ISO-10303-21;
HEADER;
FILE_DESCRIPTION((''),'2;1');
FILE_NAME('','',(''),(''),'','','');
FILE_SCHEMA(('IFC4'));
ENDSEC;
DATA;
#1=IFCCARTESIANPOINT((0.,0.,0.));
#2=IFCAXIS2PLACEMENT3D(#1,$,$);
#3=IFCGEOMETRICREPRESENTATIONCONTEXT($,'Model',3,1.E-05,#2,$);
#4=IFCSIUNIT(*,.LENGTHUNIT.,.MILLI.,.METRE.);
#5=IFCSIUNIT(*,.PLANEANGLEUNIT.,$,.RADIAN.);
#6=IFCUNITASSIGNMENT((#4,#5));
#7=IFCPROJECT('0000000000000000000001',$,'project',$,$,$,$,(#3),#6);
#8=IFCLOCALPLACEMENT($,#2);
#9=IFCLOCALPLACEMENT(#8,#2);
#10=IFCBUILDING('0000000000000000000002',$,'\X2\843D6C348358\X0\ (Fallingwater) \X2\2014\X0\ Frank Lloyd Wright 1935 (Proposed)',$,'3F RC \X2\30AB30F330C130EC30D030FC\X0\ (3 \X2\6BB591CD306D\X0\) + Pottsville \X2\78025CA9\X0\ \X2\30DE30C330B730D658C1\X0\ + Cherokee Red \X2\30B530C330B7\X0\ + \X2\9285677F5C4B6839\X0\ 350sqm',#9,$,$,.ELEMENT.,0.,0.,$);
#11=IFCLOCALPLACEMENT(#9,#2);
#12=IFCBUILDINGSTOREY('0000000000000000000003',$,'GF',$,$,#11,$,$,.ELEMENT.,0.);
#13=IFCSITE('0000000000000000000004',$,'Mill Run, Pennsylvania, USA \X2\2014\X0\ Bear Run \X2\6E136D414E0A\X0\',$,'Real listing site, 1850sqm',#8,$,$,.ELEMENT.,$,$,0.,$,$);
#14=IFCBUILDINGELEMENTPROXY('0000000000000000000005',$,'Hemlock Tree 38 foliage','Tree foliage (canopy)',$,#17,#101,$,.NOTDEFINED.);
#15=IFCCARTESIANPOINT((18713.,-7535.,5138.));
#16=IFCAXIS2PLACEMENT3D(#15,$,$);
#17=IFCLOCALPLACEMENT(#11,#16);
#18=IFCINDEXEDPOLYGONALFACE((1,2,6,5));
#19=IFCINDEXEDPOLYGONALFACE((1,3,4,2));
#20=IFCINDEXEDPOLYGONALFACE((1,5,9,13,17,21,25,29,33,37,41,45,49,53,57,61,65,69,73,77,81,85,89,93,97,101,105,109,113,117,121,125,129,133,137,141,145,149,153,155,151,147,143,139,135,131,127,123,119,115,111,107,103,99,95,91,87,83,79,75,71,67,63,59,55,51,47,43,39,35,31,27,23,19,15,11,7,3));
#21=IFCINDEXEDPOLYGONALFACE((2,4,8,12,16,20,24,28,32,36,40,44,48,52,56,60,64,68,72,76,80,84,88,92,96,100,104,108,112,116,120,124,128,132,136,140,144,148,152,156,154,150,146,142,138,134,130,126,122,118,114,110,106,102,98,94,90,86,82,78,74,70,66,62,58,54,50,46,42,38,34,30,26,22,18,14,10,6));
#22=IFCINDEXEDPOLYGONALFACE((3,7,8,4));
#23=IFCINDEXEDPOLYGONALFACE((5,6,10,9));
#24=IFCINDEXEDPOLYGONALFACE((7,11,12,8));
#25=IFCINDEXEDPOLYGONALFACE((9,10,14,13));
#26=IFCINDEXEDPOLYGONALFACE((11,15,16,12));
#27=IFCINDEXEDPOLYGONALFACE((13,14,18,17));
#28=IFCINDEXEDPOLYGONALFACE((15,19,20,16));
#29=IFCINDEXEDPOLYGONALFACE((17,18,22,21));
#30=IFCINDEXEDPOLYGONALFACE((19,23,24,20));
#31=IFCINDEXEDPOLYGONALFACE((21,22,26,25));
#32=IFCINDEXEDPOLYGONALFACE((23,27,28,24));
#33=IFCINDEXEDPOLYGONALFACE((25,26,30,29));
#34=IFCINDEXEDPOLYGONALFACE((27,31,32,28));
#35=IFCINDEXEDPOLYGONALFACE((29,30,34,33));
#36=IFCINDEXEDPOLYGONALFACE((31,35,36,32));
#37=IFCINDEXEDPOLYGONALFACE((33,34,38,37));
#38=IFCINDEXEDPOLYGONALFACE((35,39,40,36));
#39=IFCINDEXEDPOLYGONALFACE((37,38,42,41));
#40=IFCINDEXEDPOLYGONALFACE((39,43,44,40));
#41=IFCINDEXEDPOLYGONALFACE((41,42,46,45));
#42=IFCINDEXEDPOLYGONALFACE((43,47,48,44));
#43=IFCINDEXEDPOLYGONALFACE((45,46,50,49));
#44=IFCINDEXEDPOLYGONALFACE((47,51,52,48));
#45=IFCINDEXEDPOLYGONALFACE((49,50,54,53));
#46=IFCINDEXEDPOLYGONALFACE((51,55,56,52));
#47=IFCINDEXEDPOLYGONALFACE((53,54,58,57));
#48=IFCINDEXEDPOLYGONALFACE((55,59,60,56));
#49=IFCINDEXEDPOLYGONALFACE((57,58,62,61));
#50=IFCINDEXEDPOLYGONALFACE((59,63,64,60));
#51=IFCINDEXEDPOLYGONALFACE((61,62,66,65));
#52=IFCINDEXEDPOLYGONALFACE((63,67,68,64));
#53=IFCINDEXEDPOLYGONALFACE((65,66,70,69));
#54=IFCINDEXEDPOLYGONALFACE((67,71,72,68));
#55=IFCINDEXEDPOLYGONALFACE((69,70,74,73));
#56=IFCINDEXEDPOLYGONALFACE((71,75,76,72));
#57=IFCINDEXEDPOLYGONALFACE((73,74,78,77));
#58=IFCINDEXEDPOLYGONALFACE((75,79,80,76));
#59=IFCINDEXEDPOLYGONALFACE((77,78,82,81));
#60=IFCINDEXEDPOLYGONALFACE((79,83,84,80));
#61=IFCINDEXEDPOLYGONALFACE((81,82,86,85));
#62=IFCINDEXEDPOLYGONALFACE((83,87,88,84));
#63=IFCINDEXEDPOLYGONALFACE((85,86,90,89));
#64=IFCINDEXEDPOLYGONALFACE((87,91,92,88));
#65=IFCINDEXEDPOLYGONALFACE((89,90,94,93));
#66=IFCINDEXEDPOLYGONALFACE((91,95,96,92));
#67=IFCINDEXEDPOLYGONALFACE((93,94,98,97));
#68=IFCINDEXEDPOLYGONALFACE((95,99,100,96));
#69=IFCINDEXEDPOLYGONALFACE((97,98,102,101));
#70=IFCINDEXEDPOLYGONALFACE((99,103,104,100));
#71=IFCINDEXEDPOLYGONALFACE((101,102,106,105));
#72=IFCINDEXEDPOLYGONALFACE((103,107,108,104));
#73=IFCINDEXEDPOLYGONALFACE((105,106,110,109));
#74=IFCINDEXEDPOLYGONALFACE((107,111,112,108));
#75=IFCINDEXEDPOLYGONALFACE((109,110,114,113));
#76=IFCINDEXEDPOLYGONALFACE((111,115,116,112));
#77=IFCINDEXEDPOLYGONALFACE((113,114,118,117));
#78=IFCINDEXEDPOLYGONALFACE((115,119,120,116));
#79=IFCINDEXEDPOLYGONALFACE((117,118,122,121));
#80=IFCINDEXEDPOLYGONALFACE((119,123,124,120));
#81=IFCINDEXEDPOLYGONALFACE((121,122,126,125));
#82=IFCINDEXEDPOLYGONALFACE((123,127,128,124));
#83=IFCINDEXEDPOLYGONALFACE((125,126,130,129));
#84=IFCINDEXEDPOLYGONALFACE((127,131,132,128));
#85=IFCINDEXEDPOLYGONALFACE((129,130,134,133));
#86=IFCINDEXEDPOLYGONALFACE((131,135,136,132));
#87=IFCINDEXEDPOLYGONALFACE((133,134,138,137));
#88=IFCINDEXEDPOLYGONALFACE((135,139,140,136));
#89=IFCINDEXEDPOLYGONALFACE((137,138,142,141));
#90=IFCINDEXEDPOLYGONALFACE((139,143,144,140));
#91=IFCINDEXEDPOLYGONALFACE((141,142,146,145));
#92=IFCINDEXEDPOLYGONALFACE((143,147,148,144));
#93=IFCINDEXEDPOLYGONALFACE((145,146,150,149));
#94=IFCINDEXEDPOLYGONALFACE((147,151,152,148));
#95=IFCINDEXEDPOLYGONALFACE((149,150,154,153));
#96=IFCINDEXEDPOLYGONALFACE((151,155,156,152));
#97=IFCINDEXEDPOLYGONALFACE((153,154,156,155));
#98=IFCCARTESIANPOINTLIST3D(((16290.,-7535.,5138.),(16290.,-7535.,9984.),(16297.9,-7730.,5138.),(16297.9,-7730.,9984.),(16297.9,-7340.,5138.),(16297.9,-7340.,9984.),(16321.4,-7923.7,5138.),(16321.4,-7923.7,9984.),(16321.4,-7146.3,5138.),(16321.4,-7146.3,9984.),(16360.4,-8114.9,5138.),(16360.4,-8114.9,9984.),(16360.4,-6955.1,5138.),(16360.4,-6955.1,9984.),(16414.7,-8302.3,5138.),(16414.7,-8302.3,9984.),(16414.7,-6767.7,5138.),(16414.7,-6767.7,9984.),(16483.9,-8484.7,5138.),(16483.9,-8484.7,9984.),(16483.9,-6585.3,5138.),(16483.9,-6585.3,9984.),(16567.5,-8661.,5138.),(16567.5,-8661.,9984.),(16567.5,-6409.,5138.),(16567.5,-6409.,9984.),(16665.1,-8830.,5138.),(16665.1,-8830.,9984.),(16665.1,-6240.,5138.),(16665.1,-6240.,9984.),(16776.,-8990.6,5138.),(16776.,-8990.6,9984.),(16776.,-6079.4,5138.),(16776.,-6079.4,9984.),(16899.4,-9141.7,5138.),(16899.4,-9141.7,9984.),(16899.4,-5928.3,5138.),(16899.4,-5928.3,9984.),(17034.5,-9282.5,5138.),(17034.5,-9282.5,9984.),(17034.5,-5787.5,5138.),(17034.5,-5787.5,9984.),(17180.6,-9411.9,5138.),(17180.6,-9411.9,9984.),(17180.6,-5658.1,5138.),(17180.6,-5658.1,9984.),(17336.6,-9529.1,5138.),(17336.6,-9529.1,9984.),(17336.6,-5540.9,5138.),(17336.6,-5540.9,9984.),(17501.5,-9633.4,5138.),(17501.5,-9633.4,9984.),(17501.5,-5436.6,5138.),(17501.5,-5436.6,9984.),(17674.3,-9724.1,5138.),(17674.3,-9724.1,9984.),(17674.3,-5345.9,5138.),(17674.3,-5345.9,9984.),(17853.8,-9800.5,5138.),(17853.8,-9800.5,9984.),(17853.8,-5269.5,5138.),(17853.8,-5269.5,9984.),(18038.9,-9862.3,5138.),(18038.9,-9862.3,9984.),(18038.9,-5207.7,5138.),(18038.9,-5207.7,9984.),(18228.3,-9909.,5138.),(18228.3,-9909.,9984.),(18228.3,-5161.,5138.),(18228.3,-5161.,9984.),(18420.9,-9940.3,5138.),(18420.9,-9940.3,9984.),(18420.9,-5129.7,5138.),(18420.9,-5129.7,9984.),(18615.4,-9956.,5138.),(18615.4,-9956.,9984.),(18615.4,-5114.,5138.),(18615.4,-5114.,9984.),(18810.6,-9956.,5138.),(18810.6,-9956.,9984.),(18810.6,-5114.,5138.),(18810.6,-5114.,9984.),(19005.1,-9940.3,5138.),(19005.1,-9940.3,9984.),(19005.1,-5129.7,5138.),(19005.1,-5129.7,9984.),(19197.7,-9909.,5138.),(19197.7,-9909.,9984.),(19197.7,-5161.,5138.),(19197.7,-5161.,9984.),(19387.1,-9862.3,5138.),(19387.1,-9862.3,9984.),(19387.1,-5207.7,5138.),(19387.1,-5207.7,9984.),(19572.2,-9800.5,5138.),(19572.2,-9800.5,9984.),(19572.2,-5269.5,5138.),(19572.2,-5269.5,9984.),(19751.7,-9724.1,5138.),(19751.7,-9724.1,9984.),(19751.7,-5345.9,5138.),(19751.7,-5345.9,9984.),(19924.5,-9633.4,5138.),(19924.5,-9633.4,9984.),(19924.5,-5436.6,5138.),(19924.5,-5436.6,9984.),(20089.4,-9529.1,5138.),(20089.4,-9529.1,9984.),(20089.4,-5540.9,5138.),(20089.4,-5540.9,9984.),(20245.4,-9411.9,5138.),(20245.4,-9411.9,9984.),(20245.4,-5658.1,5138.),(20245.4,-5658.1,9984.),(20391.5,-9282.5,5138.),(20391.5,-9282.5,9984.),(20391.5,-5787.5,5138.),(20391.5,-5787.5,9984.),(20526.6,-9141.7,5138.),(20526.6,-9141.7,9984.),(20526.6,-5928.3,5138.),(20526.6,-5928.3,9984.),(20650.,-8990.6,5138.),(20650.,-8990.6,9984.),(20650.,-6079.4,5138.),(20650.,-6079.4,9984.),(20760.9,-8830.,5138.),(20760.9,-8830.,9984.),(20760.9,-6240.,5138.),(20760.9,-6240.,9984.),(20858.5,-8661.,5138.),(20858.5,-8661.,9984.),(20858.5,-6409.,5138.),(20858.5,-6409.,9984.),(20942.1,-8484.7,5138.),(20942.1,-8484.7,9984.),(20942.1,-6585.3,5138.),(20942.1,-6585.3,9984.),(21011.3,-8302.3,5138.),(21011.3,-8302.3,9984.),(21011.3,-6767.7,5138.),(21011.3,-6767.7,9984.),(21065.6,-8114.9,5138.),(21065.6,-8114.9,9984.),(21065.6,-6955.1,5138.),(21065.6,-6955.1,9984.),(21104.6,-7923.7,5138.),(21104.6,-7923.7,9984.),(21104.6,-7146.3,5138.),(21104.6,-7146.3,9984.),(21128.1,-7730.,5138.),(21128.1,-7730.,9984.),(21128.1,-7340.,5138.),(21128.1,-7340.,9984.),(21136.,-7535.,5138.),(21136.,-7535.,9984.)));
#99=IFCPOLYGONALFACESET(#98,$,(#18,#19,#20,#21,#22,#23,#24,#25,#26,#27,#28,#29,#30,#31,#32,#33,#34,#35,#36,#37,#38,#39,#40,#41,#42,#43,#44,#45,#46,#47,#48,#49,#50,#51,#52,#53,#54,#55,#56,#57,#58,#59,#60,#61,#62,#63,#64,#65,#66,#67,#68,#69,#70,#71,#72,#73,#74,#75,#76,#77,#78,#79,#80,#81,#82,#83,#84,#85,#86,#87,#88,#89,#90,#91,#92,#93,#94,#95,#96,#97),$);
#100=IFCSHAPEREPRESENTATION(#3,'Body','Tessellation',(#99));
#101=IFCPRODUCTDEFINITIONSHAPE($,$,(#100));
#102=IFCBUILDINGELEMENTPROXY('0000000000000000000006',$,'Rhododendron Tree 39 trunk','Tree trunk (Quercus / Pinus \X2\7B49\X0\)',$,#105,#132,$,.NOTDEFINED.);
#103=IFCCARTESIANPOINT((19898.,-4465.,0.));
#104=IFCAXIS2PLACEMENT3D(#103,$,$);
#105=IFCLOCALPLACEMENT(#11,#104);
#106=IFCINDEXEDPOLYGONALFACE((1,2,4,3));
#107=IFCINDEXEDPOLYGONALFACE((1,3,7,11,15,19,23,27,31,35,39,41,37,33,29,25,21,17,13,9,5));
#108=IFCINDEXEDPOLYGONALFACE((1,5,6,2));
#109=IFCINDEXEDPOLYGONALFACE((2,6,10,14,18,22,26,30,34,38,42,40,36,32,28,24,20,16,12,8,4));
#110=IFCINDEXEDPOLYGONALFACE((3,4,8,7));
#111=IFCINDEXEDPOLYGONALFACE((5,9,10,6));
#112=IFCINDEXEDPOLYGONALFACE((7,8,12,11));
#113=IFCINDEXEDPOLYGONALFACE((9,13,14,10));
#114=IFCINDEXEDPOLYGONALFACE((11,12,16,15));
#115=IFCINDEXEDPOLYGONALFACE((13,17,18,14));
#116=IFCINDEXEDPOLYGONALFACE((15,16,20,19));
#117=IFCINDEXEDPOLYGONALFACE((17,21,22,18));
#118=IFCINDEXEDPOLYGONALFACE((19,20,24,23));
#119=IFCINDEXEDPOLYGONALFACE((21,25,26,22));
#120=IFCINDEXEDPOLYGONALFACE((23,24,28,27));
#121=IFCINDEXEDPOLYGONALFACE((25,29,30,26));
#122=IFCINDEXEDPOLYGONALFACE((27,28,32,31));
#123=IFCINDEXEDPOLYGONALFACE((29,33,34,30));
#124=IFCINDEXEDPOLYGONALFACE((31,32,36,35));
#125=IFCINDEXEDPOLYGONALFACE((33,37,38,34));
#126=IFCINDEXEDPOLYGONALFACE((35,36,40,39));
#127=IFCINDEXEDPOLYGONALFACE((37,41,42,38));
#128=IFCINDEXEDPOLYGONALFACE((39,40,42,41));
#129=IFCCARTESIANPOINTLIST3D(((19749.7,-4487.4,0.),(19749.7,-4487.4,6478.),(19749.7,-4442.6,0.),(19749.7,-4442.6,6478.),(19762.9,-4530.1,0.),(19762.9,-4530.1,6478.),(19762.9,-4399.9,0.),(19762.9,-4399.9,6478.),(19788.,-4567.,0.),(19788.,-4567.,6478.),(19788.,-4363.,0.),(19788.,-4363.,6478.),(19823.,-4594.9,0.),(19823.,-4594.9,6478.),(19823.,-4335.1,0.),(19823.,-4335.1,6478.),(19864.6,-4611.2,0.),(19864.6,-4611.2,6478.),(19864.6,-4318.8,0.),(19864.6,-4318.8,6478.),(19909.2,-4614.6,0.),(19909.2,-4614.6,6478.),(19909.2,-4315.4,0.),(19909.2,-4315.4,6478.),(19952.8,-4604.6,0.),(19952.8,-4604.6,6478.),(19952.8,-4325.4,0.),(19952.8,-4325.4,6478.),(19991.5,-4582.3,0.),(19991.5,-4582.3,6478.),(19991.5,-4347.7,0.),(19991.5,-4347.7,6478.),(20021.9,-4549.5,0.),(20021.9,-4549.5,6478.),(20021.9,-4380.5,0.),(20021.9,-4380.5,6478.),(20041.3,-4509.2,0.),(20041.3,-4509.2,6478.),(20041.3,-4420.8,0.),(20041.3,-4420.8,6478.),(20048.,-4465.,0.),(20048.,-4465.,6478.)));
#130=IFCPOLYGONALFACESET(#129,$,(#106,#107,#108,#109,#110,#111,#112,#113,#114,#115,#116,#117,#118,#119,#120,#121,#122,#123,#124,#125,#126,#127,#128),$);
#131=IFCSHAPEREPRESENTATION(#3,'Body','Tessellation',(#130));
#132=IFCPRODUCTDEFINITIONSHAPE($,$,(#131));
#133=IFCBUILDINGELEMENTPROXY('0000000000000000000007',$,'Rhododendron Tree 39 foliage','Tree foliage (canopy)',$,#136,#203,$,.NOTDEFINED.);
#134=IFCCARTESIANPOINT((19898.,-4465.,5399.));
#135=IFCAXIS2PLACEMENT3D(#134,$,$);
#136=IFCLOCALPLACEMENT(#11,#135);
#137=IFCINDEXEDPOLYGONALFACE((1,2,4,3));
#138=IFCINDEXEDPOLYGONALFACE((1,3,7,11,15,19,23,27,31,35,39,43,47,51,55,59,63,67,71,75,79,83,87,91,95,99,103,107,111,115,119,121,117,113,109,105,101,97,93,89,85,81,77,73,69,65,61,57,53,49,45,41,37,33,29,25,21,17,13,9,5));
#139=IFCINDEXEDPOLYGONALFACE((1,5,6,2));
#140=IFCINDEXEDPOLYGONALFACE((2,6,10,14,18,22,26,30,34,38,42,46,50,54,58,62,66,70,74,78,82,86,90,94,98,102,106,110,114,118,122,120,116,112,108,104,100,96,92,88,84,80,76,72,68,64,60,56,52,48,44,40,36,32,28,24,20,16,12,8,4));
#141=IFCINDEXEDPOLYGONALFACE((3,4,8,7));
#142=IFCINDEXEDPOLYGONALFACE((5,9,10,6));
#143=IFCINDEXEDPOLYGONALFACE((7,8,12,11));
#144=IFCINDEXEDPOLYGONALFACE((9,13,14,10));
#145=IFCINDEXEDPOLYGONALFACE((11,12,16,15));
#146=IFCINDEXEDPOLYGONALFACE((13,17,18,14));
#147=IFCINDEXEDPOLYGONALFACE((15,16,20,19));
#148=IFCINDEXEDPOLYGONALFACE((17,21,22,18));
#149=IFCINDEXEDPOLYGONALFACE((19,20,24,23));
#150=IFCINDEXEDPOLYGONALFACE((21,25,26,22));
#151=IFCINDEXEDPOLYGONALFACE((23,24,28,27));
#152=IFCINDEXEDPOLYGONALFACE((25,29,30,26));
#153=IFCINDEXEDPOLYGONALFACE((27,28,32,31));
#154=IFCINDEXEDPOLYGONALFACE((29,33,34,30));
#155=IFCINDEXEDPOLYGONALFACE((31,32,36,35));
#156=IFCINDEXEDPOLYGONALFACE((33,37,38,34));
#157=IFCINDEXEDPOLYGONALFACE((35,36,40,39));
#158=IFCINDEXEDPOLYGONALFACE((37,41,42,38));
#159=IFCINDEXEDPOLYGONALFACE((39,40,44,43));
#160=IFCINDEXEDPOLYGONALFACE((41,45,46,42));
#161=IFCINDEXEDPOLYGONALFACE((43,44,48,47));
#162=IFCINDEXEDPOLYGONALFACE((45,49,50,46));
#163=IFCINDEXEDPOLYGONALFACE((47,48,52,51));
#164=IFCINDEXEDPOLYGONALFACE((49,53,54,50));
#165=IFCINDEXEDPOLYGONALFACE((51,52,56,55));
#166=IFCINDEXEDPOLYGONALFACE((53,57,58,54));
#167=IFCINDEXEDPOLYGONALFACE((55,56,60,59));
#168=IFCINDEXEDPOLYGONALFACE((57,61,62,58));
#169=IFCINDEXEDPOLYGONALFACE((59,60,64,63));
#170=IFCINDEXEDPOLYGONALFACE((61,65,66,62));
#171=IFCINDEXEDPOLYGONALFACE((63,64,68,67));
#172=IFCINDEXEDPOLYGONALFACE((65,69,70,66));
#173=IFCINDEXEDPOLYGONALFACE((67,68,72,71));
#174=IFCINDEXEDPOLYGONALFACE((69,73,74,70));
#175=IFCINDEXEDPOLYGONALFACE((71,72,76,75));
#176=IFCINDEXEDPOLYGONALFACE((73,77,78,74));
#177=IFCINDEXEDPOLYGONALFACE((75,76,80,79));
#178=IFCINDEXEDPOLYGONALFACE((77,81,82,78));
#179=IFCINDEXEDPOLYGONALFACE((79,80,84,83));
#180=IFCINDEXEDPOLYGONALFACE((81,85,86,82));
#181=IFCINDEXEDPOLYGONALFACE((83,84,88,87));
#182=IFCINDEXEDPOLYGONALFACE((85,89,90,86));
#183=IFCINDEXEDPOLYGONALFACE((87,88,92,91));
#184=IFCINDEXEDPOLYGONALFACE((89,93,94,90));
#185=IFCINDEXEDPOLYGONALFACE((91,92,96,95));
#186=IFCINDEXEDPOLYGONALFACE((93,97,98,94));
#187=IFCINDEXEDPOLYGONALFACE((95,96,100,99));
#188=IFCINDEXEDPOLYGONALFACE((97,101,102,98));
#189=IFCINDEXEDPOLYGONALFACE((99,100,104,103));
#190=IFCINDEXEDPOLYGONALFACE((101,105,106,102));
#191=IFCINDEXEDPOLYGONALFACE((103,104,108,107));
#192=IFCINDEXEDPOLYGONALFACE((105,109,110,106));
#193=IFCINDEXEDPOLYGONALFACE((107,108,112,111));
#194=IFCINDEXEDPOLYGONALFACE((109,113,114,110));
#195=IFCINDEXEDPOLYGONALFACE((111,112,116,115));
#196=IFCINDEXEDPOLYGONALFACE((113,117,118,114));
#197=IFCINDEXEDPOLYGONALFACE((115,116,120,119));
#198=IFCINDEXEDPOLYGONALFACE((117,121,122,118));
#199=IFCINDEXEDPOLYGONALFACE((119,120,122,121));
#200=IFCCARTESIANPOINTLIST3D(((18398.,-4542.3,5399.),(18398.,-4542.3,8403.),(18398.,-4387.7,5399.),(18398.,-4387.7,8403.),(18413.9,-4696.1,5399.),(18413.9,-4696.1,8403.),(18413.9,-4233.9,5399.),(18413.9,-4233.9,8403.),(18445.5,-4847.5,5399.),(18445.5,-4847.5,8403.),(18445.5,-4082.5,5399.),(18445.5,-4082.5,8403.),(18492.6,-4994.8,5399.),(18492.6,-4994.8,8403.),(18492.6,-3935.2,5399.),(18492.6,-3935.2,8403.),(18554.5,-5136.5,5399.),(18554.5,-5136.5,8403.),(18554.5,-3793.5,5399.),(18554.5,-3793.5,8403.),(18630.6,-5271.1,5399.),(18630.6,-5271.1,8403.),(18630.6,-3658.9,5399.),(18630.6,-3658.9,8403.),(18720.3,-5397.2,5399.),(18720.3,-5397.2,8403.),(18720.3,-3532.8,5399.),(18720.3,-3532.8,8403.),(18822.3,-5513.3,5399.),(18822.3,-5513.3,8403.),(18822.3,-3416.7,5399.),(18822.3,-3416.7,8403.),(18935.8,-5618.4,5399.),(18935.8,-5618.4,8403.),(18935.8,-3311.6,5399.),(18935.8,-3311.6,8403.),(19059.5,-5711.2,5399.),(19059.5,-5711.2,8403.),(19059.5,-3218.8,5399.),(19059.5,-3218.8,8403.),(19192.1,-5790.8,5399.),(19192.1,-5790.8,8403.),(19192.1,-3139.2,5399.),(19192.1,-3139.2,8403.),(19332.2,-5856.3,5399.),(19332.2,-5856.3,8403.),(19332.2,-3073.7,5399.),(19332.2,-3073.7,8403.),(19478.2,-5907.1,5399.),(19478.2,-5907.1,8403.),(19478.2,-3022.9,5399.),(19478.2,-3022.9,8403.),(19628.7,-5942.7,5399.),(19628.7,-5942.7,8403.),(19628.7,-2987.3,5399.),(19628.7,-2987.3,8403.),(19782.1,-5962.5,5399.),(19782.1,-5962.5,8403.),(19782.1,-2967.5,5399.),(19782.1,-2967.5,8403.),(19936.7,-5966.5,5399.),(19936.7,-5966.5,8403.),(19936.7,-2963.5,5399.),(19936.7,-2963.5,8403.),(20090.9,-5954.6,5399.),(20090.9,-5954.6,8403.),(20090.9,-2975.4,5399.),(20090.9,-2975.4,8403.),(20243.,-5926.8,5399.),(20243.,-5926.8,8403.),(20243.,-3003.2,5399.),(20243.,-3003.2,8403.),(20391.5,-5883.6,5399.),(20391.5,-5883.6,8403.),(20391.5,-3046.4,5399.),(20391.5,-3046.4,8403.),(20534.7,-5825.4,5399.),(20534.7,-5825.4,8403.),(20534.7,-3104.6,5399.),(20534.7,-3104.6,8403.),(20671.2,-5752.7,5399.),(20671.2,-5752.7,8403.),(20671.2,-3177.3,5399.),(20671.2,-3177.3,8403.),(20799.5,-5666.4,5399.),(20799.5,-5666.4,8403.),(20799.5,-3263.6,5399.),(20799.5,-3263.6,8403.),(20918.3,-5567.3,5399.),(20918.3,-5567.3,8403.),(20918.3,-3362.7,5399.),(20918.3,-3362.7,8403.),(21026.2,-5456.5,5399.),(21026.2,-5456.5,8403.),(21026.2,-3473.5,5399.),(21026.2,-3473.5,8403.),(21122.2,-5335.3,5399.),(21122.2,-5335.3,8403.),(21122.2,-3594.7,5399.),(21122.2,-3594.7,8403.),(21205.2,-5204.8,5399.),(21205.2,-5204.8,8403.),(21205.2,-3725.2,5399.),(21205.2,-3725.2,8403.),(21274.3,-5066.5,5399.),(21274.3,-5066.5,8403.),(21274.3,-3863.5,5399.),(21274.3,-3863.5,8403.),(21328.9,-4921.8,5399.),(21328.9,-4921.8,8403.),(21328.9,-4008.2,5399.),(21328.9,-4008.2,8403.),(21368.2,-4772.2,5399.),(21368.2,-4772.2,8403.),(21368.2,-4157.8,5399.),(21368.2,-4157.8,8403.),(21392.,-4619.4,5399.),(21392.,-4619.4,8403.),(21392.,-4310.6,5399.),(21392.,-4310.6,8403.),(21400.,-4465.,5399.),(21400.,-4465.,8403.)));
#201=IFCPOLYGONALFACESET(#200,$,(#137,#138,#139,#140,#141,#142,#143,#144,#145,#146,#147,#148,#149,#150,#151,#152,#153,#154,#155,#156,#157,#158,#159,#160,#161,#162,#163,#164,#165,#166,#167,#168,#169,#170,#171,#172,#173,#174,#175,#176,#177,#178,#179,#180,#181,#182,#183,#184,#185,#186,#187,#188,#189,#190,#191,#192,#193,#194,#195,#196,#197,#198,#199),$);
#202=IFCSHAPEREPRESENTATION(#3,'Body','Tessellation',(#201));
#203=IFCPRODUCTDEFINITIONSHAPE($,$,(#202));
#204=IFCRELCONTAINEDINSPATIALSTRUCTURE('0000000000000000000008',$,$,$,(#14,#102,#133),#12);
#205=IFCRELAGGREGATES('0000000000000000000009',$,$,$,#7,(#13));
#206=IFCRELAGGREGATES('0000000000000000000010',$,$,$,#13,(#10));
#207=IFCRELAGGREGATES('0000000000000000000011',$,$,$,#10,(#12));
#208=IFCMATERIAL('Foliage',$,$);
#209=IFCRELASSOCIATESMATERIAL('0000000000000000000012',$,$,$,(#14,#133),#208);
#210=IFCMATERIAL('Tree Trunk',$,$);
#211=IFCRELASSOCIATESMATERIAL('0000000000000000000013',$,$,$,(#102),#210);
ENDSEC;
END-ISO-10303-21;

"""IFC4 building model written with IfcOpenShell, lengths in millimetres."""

from ifc_helpers import new_model, si_unit, frame, origin, origin_2d, place, context, project, spatial, circle, extrude, material, element, save


model = new_model("IFC4")

# Units and contexts
model_context = context("Model", 3, precision=1e-05, world=origin())
ifc_project = project(units=[si_unit("LENGTHUNIT", "METRE", prefix="MILLI"), si_unit("PLANEANGLEUNIT", "RADIAN")], contexts=[model_context])

# Site, building, storey
site_placement = place(None, origin())
site = spatial("IfcSite", under=ifc_project, at=site_placement, Name="Mill Run, Pennsylvania, USA — Bear Run 渓流上", ObjectType="Real listing site, 1850sqm", CompositionType="ELEMENT", RefElevation=0.0)
building_placement = place(site_placement, origin())
building = spatial("IfcBuilding", under=site, at=building_placement, Name="落水荘 (Fallingwater) — Frank Lloyd Wright 1935 (Proposed)", ObjectType="3F RC カンチレバー (3 段重ね) + Pottsville 砂岩 マッシブ壁 + Cherokee Red サッシ + 銅板屋根 350sqm", CompositionType="ELEMENT", ElevationOfRefHeight=0.0, ElevationOfTerrain=0.0)
storey_placement = place(building_placement, origin())
storey = spatial("IfcBuildingStorey", under=building, at=storey_placement, Name="GF", CompositionType="ELEMENT", Elevation=0.0)

# Building element proxies
ifc_material_1 = material(Name="Tree Trunk")
ifc_material_2 = material(Name="Foliage")
proxy_1_placement = place(storey_placement, frame((18713.0, -7535.0, 5138.0)))
element("IfcBuildingElementProxy", 1, at=proxy_1_placement, inside=storey, material=ifc_material_2, Name="Hemlock Tree 38 foliage", Description="Tree foliage (canopy)", PredefinedType="NOTDEFINED", context=model_context, shape_type="SweptSolid", body=[
    extrude(circle(Radius=2423.0, at=origin_2d()), frame((18713.0, -7535.0, 5138.0)), (0.0, 0.0, 1.0), 4846.0),
])
proxy_2_placement = place(storey_placement, frame((19898.0, -4465.0, 0.0)))
element("IfcBuildingElementProxy", 2, at=proxy_2_placement, inside=storey, material=ifc_material_1, Name="Rhododendron Tree 39 trunk", Description="Tree trunk (Quercus / Pinus 等)", PredefinedType="NOTDEFINED", context=model_context, shape_type="SweptSolid", body=[
    extrude(circle(Radius=150.0, at=origin_2d()), frame((19898.0, -4465.0, 0.0)), (0.0, 0.0, 1.0), 6478.0),
])
proxy_3_placement = place(storey_placement, frame((19898.0, -4465.0, 5399.0)))
element("IfcBuildingElementProxy", 3, at=proxy_3_placement, inside=storey, material=ifc_material_2, Name="Rhododendron Tree 39 foliage", Description="Tree foliage (canopy)", PredefinedType="NOTDEFINED", context=model_context, shape_type="SweptSolid", body=[
    extrude(circle(Radius=1502.0, at=origin_2d()), frame((19898.0, -4465.0, 5399.0)), (0.0, 0.0, 1.0), 3004.0),
])

save(model, "model.ifc")
